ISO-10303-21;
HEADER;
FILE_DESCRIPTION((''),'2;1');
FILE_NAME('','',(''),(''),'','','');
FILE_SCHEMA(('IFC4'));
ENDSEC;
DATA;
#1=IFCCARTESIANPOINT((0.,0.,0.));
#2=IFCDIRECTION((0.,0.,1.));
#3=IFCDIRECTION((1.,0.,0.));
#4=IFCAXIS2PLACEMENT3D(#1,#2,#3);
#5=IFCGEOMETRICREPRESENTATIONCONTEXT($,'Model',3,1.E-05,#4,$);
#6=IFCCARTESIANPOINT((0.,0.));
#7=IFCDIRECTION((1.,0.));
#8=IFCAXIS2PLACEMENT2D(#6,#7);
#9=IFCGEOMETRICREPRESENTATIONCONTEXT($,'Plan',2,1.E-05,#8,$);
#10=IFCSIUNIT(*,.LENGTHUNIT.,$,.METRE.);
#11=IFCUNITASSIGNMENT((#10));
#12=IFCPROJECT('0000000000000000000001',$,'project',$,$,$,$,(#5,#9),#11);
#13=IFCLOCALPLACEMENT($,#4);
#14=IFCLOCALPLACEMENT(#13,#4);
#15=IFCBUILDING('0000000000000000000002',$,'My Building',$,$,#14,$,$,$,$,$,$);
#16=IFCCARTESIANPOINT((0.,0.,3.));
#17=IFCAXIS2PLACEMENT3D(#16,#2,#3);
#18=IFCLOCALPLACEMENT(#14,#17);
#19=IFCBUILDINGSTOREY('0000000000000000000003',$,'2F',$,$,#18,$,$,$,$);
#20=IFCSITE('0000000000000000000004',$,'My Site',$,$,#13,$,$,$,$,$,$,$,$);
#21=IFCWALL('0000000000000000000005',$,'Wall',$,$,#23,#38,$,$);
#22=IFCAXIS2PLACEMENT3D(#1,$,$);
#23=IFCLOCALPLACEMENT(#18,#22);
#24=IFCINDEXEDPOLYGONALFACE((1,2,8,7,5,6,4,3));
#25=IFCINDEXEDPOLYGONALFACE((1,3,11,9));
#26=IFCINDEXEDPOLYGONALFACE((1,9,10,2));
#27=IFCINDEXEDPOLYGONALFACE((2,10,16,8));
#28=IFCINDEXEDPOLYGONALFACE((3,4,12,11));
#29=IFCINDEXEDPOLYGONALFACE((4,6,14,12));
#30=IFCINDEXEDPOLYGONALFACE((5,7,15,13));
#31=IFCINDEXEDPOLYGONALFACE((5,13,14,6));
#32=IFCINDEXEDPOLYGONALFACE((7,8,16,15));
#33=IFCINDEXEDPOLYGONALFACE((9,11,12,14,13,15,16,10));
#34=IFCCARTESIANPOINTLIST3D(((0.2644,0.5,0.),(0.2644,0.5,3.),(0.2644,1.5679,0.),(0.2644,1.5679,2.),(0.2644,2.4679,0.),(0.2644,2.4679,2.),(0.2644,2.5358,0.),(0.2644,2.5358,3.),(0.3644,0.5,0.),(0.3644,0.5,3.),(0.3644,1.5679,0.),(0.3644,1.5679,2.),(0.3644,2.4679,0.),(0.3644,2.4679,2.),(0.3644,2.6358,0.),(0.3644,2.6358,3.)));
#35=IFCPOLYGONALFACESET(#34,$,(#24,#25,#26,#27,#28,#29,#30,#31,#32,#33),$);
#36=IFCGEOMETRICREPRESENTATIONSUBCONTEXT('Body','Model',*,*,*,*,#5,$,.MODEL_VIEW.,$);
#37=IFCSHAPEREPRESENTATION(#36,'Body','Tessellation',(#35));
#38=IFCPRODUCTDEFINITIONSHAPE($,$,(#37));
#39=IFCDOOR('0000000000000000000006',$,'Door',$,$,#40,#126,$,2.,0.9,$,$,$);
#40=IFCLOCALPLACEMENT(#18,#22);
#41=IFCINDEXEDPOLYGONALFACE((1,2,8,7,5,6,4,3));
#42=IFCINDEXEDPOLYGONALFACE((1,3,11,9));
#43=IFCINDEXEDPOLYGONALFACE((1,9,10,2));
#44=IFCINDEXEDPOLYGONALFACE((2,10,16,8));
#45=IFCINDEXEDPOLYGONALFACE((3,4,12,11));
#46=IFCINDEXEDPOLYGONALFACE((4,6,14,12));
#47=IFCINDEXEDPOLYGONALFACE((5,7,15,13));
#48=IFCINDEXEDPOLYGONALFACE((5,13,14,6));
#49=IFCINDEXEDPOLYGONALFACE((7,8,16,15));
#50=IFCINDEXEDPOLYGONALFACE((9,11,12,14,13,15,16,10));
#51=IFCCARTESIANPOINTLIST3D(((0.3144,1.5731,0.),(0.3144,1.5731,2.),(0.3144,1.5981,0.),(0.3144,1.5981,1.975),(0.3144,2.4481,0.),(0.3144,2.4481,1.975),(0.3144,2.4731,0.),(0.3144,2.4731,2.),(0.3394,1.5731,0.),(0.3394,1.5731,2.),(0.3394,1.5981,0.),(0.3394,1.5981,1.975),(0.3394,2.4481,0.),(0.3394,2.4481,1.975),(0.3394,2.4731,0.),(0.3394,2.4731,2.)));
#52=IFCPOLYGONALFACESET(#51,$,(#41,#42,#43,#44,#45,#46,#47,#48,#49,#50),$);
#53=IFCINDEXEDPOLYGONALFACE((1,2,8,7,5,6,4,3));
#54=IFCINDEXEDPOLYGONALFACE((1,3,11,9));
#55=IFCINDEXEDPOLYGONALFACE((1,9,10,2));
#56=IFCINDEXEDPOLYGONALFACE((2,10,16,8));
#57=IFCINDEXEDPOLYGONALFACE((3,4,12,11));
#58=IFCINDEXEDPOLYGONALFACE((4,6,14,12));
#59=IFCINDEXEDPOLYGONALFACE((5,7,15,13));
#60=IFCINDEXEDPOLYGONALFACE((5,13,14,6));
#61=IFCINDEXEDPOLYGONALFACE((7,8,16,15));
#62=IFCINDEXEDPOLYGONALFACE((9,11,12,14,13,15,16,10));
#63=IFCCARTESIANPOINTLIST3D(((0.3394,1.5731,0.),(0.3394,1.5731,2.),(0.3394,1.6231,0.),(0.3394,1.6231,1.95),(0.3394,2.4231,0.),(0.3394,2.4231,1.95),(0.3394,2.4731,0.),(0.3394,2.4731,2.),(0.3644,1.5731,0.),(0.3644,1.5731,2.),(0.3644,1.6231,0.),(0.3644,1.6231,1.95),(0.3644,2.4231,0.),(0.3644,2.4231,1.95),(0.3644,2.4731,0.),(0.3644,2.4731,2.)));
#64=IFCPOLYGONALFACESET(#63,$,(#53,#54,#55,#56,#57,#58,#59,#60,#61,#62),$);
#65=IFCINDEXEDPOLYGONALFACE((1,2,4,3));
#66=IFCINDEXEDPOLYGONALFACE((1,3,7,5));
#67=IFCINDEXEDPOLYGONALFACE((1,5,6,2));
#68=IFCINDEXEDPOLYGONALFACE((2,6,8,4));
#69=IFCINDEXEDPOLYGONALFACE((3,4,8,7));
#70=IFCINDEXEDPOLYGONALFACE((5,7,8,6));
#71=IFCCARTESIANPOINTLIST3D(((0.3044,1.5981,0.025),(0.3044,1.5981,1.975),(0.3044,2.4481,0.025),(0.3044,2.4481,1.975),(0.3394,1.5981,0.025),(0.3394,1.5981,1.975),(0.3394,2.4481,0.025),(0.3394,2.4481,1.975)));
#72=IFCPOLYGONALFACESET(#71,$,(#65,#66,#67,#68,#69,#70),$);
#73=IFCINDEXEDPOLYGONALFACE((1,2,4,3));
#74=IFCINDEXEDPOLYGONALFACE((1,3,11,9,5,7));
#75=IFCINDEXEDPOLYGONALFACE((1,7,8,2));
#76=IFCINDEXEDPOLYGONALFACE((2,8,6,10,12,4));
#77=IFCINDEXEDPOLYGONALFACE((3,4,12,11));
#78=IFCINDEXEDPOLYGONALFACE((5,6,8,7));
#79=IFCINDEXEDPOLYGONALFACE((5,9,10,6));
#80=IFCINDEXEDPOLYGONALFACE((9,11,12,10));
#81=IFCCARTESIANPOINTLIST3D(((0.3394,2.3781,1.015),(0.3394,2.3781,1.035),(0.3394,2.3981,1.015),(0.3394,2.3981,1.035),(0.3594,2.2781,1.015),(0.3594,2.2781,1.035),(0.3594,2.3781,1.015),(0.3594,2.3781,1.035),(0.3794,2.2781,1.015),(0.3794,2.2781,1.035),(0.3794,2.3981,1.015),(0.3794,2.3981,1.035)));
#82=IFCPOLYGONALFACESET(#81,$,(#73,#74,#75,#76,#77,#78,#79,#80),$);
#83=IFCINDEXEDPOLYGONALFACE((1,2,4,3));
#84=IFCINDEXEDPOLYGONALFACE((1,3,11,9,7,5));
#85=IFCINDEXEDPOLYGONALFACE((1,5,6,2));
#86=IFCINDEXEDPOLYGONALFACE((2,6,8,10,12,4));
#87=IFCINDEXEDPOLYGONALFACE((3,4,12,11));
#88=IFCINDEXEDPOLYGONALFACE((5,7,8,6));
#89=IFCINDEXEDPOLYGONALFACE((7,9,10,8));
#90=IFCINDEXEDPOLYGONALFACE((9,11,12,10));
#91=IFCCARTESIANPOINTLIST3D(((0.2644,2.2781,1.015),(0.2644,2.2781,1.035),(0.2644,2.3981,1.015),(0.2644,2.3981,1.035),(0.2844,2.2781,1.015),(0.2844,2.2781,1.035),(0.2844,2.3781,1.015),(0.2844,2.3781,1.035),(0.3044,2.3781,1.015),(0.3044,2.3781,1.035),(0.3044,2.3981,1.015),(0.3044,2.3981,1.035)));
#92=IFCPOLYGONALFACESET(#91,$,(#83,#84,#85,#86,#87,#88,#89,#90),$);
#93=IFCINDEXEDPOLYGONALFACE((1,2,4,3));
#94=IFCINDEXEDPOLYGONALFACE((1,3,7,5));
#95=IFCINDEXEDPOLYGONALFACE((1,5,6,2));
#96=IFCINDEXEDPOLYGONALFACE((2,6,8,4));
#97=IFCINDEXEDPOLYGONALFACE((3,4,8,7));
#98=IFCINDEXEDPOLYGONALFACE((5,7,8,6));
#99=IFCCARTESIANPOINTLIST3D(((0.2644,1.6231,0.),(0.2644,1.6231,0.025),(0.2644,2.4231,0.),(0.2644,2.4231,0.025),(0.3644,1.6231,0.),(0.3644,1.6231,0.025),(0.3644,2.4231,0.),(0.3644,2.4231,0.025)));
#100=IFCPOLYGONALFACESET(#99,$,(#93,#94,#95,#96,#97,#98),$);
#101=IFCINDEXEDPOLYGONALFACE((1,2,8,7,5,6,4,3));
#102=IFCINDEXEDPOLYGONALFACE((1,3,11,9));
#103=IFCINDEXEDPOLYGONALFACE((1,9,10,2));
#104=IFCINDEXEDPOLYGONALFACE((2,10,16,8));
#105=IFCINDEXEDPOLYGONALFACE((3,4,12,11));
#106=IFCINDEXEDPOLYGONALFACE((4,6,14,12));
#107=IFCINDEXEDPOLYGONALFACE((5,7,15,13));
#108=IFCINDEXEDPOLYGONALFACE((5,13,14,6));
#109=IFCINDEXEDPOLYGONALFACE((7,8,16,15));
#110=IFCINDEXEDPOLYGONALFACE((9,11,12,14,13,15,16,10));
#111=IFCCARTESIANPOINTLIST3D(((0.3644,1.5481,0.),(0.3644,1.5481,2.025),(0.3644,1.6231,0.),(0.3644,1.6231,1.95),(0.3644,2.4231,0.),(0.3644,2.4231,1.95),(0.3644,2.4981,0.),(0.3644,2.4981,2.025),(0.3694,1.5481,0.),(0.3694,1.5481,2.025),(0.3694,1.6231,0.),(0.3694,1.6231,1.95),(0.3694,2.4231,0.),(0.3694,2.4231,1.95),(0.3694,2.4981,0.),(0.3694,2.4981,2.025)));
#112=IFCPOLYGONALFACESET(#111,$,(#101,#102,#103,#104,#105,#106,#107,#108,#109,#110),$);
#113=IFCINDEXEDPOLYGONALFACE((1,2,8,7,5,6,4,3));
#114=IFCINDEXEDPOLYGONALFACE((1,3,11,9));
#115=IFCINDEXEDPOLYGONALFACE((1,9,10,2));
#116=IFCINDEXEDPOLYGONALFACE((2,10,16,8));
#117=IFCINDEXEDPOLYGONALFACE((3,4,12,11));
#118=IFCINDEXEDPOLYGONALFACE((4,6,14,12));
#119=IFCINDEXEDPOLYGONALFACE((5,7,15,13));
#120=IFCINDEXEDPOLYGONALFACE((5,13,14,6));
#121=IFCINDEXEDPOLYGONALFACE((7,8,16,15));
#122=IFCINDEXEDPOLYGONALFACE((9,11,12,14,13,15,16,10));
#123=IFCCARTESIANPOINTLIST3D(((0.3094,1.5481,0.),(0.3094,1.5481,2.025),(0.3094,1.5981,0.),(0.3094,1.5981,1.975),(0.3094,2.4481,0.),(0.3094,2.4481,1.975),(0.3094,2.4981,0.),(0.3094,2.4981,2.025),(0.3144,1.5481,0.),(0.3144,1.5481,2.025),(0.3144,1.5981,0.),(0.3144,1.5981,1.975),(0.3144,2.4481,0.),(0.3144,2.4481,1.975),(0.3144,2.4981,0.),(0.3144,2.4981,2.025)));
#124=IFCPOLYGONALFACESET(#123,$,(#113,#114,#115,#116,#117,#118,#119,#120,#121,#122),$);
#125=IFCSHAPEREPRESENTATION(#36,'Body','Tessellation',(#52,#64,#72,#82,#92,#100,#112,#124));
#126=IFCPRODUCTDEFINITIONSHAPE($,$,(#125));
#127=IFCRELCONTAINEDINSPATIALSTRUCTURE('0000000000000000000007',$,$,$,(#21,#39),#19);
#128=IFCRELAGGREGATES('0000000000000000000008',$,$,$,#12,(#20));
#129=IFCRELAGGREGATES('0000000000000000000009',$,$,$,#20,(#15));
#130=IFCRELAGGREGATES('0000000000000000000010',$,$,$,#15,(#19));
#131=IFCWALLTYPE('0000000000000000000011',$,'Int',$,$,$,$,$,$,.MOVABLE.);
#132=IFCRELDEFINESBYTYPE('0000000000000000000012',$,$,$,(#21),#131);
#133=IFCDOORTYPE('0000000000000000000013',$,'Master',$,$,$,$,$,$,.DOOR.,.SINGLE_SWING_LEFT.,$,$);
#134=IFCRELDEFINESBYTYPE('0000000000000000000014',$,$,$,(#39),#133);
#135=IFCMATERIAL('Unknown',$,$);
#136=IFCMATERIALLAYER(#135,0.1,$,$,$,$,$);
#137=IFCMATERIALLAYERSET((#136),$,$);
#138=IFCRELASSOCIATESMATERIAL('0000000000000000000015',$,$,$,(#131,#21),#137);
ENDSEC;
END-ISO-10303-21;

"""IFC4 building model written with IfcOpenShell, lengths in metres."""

from ifc_helpers import new_model, entity, si_unit, frame, origin_with_axes, origin_2d_with_axis, place, context, subcontext, project, spatial, line, indexed_curve, outline, extrude, shape, source, transform, mapped, material, layer, layer_set, layer_usage, type_object, type_shapes, element, fill, save


model = new_model("IFC4")

# Units and contexts
model_context = context("Model", 3, precision=1e-05, world=origin_with_axes())
plan_context = context("Plan", 2, precision=1e-05, world=origin_2d_with_axis())
body_context_1 = subcontext(model_context, "Body", "Model", "MODEL_VIEW")
body_context_2 = subcontext(plan_context, "Body", "Plan", "PLAN_VIEW")
ifc_project = project(units=[si_unit("LENGTHUNIT", "METRE")], contexts=[model_context, plan_context])

# Site, building, storey
site_placement = place(None, origin_with_axes())
site = spatial("IfcSite", under=ifc_project, at=site_placement, Name="My Site")
building_placement = place(site_placement, origin_with_axes())
building = spatial("IfcBuilding", under=site, at=building_placement, Name="My Building")
storey_placement = place(building_placement, frame((0.0, 0.0, 3.0), z_axis=(0.0, 0.0, 1.0), x_axis=(1.0, 0.0, 0.0)))
storey = spatial("IfcBuildingStorey", under=building, at=storey_placement, Name="2F")

# Shared definitions
ifc_material = material(Name="Unknown")

# Shared definitions
ifc_layer_1 = layer(ifc_material, 0.1)
ifc_layer_set_1 = layer_set([ifc_layer_1])
wall_type_1 = type_object("IfcWallType", Name="Int", PredefinedType="MOVABLE", material=ifc_layer_set_1)

# Wall, opening, door
ifc_layer_usage_1 = layer_usage(ifc_layer_set_1, "AXIS2", "POSITIVE", 0.0)
wall_1_placement = place(storey_placement, frame((0.2644, 2.5358, 0.0), z_axis=(0.0, 0.0, 1.0), x_axis=(0.0, -1.0, 0.0)))
wall_1 = element("IfcWall", 1, at=wall_1_placement, inside=storey, type_object=wall_type_1, material=ifc_layer_usage_1, Name="Wall", context=body_context_1, shape_type="SweptSolid", body=[
    extrude(outline(indexed_curve([(0.0, 0.0), (-0.1, 0.1), (2.0358, 0.1), (2.0358, 0.0)], segments=[line(1, 2, 3, 4, 1)])), origin_with_axes(), (0.0, 0.0, 1.0), 3.0),
])
shared_shape_1 = source(origin_with_axes(), body_context_1, "Body", "SweptSolid", [
    extrude(outline(indexed_curve([(0.0, 0.0), (0.9, 0.0), (0.9, 2.0), (0.0, 2.0)], segments=[line(1, 2, 3, 4, 1)])), frame((0.0, -0.6, 0.0), z_axis=(0.0, -1.0, 0.0), x_axis=(1.0, 0.0, 0.0)), (0.0, 0.0, -1.0), 1.2),
])
opening_1_placement = place(wall_1_placement, frame((0.9679, 0.1, 0.0), z_axis=(0.0, 0.0, 1.0), x_axis=(-1.0, 0.0, 0.0)))
opening_1 = element("IfcOpeningElement", 2, at=opening_1_placement, cuts=wall_1, PredefinedType="OPENING", context=body_context_1, shape_type="MappedRepresentation", body=[
    mapped(shared_shape_1, transform((0.0, 0.0, 0.0), x_axis=(1.0, 0.0, 0.0), y_axis=(0.0, 1.0, 0.0), z_axis=(0.0, 0.0, 1.0), scale=1.0)),
])
door_type_1 = type_object("IfcDoorType", Name="Master", OperationType="SINGLE_SWING_LEFT", PredefinedType="DOOR")
shared_shape_2 = source(origin_with_axes(), body_context_1, "Body", "SweptSolid", [
    extrude(outline(indexed_curve([(0.025, 0.0), (0.025, 1.975), (0.875, 1.975), (0.875, 0.0), (0.9, 0.0), (0.9, 2.0), (0.0, 2.0), (0.0, 0.0), (0.025, 0.0)])), frame((0.0, 0.025, 0.0), z_axis=(0.0, -1.0, 0.0), x_axis=(1.0, 0.0, 0.0)), (0.0, 0.0, -1.0), 0.025),
    extrude(outline(indexed_curve([(0.0, 0.0), (0.0, 2.0), (0.9, 2.0), (0.9, 0.0), (0.85, 0.0), (0.85, 1.95), (0.05, 1.95), (0.05, 0.0)], segments=[line(1, 2, 3, 4, 5, 6, 7, 8, 1)])), frame((0.0, 0.0, 0.0), z_axis=(0.0, -1.0, 0.0), x_axis=(1.0, 0.0, 0.0)), (0.0, 0.0, -1.0), 0.025),
    extrude(outline(indexed_curve([(0.0, 0.0), (0.85, 0.0), (0.85, 0.035), (0.0, 0.035)], segments=[line(1, 2, 3, 4, 1)])), frame((0.025, 0.025, 0.025), z_axis=(0.0, 0.0, 1.0), x_axis=(1.0, 0.0, 0.0)), (0.0, 0.0, 1.0), 1.95),
    extrude(outline(indexed_curve([(-0.02, 0.0), (-0.02, -0.02), (-0.12, -0.02), (-0.12, -0.04), (0.0, -0.04), (0.0, 0.0), (-0.02, 0.0)])), frame((0.825, 0.025, 1.015), z_axis=(0.0, 0.0, 1.0), x_axis=(1.0, 0.0, 0.0)), (0.0, 0.0, 1.0), 0.02),
    extrude(outline(indexed_curve([(0.0, 0.0), (0.0, 0.04), (-0.12, 0.04), (-0.12, 0.02), (-0.02, 0.02), (-0.02, 0.0)], segments=[line(1, 2, 3, 4, 5, 6, 1)])), frame((0.825, 0.06, 1.015), z_axis=(0.0, 0.0, 1.0), x_axis=(1.0, 0.0, 0.0)), (0.0, 0.0, 1.0), 0.02),
    extrude(outline(indexed_curve([(0.0, 0.0), (0.8, 0.0), (0.8, 0.1), (0.0, 0.1)], segments=[line(1, 2, 3, 4, 1)])), frame((0.05, 0.0, 0.0), z_axis=(0.0, 0.0, 1.0), x_axis=(1.0, 0.0, 0.0)), (0.0, 0.0, 1.0), 0.025),
    extrude(outline(indexed_curve([(0.0, 0.0), (0.0, 2.025), (0.95, 2.025), (0.95, 0.0), (0.875, 0.0), (0.875, 1.95), (0.075, 1.95), (0.075, 0.0)], segments=[line(1, 2, 3, 4, 5, 6, 7, 8, 1)])), frame((-0.025, -0.005, 0.0), z_axis=(0.0, -1.0, 0.0), x_axis=(1.0, 0.0, 0.0)), (0.0, 0.0, -1.0), 0.005),
    extrude(outline(indexed_curve([(0.0, 0.0), (0.0, 2.025), (0.95, 2.025), (0.95, 0.0), (0.9, 0.0), (0.9, 1.975), (0.05, 1.975), (0.05, 0.0), (0.0, 0.0)])), frame((-0.025, 0.05, 0.0), z_axis=(0.0, -1.0, 0.0), x_axis=(1.0, 0.0, 0.0)), (0.0, 0.0, -1.0), 0.005),
])
shared_shape_3 = source(origin_with_axes(), body_context_2, "Body", "Curve2D", [
    entity("IfcIndexedPolyCurve", entity("IfcCartesianPointList2D", [[0.0, 0.0], [0.0, 0.05], [0.025, 0.05], [0.025, 0.025], [0.05, 0.025], [0.05, 0.0]]), [entity("IfcLineIndex", [1, 2, 3, 4, 5, 6, 1])]),
    entity("IfcIndexedPolyCurve", entity("IfcCartesianPointList2D", [[0.9, 0.0], [0.9, 0.05], [0.875, 0.05], [0.875, 0.025], [0.85, 0.025], [0.85, 0.0]]), [entity("IfcLineIndex", [1, 2, 3, 4, 5, 6, 1])]),
    entity("IfcTrimmedCurve", entity("IfcEllipse", entity("IfcAxis2Placement2D", entity("IfcCartesianPoint", [0.06, 0.05]), entity("IfcDirection", [1.0, 0.0])), 0.815, 0.85), [entity("IfcCartesianPoint", [0.875, 0.05])], [entity("IfcCartesianPoint", [0.06, 0.9])], True, "CARTESIAN"),
    entity("IfcIndexedPolyCurve", entity("IfcCartesianPointList2D", [[0.025, 0.05], [0.06, 0.05], [0.06, 0.9], [0.025, 0.9]]), [entity("IfcLineIndex", [1, 2, 3, 4, 1])]),
])
type_shapes(door_type_1, [shared_shape_2, shared_shape_3])
door_1_placement = place(opening_1_placement, frame((0.0052, 0.0, 0.0), z_axis=(0.0, 0.0, 1.0), x_axis=(1.0, 0.0, 0.0)))
door_1 = element("IfcDoor", 3, at=door_1_placement, inside=storey, type_object=door_type_1, Name="Door", OverallHeight=2.0, OverallWidth=0.9, shapes=[
    shape(body_context_1, "Body", "MappedRepresentation", [mapped(shared_shape_2, transform((0.0, 0.0, 0.0), x_axis=(1.0, 0.0, 0.0), y_axis=(0.0, 1.0, 0.0), z_axis=(0.0, 0.0, 1.0), scale=1.0))]),
    shape(body_context_2, "Body", "MappedRepresentation", [mapped(shared_shape_3, transform((0.0, 0.0, 0.0), x_axis=(1.0, 0.0, 0.0), y_axis=(0.0, 1.0, 0.0), z_axis=(0.0, 0.0, 1.0), scale=1.0))]),
])
fill(opening_1, door_1)

save(model, "model.ifc")
